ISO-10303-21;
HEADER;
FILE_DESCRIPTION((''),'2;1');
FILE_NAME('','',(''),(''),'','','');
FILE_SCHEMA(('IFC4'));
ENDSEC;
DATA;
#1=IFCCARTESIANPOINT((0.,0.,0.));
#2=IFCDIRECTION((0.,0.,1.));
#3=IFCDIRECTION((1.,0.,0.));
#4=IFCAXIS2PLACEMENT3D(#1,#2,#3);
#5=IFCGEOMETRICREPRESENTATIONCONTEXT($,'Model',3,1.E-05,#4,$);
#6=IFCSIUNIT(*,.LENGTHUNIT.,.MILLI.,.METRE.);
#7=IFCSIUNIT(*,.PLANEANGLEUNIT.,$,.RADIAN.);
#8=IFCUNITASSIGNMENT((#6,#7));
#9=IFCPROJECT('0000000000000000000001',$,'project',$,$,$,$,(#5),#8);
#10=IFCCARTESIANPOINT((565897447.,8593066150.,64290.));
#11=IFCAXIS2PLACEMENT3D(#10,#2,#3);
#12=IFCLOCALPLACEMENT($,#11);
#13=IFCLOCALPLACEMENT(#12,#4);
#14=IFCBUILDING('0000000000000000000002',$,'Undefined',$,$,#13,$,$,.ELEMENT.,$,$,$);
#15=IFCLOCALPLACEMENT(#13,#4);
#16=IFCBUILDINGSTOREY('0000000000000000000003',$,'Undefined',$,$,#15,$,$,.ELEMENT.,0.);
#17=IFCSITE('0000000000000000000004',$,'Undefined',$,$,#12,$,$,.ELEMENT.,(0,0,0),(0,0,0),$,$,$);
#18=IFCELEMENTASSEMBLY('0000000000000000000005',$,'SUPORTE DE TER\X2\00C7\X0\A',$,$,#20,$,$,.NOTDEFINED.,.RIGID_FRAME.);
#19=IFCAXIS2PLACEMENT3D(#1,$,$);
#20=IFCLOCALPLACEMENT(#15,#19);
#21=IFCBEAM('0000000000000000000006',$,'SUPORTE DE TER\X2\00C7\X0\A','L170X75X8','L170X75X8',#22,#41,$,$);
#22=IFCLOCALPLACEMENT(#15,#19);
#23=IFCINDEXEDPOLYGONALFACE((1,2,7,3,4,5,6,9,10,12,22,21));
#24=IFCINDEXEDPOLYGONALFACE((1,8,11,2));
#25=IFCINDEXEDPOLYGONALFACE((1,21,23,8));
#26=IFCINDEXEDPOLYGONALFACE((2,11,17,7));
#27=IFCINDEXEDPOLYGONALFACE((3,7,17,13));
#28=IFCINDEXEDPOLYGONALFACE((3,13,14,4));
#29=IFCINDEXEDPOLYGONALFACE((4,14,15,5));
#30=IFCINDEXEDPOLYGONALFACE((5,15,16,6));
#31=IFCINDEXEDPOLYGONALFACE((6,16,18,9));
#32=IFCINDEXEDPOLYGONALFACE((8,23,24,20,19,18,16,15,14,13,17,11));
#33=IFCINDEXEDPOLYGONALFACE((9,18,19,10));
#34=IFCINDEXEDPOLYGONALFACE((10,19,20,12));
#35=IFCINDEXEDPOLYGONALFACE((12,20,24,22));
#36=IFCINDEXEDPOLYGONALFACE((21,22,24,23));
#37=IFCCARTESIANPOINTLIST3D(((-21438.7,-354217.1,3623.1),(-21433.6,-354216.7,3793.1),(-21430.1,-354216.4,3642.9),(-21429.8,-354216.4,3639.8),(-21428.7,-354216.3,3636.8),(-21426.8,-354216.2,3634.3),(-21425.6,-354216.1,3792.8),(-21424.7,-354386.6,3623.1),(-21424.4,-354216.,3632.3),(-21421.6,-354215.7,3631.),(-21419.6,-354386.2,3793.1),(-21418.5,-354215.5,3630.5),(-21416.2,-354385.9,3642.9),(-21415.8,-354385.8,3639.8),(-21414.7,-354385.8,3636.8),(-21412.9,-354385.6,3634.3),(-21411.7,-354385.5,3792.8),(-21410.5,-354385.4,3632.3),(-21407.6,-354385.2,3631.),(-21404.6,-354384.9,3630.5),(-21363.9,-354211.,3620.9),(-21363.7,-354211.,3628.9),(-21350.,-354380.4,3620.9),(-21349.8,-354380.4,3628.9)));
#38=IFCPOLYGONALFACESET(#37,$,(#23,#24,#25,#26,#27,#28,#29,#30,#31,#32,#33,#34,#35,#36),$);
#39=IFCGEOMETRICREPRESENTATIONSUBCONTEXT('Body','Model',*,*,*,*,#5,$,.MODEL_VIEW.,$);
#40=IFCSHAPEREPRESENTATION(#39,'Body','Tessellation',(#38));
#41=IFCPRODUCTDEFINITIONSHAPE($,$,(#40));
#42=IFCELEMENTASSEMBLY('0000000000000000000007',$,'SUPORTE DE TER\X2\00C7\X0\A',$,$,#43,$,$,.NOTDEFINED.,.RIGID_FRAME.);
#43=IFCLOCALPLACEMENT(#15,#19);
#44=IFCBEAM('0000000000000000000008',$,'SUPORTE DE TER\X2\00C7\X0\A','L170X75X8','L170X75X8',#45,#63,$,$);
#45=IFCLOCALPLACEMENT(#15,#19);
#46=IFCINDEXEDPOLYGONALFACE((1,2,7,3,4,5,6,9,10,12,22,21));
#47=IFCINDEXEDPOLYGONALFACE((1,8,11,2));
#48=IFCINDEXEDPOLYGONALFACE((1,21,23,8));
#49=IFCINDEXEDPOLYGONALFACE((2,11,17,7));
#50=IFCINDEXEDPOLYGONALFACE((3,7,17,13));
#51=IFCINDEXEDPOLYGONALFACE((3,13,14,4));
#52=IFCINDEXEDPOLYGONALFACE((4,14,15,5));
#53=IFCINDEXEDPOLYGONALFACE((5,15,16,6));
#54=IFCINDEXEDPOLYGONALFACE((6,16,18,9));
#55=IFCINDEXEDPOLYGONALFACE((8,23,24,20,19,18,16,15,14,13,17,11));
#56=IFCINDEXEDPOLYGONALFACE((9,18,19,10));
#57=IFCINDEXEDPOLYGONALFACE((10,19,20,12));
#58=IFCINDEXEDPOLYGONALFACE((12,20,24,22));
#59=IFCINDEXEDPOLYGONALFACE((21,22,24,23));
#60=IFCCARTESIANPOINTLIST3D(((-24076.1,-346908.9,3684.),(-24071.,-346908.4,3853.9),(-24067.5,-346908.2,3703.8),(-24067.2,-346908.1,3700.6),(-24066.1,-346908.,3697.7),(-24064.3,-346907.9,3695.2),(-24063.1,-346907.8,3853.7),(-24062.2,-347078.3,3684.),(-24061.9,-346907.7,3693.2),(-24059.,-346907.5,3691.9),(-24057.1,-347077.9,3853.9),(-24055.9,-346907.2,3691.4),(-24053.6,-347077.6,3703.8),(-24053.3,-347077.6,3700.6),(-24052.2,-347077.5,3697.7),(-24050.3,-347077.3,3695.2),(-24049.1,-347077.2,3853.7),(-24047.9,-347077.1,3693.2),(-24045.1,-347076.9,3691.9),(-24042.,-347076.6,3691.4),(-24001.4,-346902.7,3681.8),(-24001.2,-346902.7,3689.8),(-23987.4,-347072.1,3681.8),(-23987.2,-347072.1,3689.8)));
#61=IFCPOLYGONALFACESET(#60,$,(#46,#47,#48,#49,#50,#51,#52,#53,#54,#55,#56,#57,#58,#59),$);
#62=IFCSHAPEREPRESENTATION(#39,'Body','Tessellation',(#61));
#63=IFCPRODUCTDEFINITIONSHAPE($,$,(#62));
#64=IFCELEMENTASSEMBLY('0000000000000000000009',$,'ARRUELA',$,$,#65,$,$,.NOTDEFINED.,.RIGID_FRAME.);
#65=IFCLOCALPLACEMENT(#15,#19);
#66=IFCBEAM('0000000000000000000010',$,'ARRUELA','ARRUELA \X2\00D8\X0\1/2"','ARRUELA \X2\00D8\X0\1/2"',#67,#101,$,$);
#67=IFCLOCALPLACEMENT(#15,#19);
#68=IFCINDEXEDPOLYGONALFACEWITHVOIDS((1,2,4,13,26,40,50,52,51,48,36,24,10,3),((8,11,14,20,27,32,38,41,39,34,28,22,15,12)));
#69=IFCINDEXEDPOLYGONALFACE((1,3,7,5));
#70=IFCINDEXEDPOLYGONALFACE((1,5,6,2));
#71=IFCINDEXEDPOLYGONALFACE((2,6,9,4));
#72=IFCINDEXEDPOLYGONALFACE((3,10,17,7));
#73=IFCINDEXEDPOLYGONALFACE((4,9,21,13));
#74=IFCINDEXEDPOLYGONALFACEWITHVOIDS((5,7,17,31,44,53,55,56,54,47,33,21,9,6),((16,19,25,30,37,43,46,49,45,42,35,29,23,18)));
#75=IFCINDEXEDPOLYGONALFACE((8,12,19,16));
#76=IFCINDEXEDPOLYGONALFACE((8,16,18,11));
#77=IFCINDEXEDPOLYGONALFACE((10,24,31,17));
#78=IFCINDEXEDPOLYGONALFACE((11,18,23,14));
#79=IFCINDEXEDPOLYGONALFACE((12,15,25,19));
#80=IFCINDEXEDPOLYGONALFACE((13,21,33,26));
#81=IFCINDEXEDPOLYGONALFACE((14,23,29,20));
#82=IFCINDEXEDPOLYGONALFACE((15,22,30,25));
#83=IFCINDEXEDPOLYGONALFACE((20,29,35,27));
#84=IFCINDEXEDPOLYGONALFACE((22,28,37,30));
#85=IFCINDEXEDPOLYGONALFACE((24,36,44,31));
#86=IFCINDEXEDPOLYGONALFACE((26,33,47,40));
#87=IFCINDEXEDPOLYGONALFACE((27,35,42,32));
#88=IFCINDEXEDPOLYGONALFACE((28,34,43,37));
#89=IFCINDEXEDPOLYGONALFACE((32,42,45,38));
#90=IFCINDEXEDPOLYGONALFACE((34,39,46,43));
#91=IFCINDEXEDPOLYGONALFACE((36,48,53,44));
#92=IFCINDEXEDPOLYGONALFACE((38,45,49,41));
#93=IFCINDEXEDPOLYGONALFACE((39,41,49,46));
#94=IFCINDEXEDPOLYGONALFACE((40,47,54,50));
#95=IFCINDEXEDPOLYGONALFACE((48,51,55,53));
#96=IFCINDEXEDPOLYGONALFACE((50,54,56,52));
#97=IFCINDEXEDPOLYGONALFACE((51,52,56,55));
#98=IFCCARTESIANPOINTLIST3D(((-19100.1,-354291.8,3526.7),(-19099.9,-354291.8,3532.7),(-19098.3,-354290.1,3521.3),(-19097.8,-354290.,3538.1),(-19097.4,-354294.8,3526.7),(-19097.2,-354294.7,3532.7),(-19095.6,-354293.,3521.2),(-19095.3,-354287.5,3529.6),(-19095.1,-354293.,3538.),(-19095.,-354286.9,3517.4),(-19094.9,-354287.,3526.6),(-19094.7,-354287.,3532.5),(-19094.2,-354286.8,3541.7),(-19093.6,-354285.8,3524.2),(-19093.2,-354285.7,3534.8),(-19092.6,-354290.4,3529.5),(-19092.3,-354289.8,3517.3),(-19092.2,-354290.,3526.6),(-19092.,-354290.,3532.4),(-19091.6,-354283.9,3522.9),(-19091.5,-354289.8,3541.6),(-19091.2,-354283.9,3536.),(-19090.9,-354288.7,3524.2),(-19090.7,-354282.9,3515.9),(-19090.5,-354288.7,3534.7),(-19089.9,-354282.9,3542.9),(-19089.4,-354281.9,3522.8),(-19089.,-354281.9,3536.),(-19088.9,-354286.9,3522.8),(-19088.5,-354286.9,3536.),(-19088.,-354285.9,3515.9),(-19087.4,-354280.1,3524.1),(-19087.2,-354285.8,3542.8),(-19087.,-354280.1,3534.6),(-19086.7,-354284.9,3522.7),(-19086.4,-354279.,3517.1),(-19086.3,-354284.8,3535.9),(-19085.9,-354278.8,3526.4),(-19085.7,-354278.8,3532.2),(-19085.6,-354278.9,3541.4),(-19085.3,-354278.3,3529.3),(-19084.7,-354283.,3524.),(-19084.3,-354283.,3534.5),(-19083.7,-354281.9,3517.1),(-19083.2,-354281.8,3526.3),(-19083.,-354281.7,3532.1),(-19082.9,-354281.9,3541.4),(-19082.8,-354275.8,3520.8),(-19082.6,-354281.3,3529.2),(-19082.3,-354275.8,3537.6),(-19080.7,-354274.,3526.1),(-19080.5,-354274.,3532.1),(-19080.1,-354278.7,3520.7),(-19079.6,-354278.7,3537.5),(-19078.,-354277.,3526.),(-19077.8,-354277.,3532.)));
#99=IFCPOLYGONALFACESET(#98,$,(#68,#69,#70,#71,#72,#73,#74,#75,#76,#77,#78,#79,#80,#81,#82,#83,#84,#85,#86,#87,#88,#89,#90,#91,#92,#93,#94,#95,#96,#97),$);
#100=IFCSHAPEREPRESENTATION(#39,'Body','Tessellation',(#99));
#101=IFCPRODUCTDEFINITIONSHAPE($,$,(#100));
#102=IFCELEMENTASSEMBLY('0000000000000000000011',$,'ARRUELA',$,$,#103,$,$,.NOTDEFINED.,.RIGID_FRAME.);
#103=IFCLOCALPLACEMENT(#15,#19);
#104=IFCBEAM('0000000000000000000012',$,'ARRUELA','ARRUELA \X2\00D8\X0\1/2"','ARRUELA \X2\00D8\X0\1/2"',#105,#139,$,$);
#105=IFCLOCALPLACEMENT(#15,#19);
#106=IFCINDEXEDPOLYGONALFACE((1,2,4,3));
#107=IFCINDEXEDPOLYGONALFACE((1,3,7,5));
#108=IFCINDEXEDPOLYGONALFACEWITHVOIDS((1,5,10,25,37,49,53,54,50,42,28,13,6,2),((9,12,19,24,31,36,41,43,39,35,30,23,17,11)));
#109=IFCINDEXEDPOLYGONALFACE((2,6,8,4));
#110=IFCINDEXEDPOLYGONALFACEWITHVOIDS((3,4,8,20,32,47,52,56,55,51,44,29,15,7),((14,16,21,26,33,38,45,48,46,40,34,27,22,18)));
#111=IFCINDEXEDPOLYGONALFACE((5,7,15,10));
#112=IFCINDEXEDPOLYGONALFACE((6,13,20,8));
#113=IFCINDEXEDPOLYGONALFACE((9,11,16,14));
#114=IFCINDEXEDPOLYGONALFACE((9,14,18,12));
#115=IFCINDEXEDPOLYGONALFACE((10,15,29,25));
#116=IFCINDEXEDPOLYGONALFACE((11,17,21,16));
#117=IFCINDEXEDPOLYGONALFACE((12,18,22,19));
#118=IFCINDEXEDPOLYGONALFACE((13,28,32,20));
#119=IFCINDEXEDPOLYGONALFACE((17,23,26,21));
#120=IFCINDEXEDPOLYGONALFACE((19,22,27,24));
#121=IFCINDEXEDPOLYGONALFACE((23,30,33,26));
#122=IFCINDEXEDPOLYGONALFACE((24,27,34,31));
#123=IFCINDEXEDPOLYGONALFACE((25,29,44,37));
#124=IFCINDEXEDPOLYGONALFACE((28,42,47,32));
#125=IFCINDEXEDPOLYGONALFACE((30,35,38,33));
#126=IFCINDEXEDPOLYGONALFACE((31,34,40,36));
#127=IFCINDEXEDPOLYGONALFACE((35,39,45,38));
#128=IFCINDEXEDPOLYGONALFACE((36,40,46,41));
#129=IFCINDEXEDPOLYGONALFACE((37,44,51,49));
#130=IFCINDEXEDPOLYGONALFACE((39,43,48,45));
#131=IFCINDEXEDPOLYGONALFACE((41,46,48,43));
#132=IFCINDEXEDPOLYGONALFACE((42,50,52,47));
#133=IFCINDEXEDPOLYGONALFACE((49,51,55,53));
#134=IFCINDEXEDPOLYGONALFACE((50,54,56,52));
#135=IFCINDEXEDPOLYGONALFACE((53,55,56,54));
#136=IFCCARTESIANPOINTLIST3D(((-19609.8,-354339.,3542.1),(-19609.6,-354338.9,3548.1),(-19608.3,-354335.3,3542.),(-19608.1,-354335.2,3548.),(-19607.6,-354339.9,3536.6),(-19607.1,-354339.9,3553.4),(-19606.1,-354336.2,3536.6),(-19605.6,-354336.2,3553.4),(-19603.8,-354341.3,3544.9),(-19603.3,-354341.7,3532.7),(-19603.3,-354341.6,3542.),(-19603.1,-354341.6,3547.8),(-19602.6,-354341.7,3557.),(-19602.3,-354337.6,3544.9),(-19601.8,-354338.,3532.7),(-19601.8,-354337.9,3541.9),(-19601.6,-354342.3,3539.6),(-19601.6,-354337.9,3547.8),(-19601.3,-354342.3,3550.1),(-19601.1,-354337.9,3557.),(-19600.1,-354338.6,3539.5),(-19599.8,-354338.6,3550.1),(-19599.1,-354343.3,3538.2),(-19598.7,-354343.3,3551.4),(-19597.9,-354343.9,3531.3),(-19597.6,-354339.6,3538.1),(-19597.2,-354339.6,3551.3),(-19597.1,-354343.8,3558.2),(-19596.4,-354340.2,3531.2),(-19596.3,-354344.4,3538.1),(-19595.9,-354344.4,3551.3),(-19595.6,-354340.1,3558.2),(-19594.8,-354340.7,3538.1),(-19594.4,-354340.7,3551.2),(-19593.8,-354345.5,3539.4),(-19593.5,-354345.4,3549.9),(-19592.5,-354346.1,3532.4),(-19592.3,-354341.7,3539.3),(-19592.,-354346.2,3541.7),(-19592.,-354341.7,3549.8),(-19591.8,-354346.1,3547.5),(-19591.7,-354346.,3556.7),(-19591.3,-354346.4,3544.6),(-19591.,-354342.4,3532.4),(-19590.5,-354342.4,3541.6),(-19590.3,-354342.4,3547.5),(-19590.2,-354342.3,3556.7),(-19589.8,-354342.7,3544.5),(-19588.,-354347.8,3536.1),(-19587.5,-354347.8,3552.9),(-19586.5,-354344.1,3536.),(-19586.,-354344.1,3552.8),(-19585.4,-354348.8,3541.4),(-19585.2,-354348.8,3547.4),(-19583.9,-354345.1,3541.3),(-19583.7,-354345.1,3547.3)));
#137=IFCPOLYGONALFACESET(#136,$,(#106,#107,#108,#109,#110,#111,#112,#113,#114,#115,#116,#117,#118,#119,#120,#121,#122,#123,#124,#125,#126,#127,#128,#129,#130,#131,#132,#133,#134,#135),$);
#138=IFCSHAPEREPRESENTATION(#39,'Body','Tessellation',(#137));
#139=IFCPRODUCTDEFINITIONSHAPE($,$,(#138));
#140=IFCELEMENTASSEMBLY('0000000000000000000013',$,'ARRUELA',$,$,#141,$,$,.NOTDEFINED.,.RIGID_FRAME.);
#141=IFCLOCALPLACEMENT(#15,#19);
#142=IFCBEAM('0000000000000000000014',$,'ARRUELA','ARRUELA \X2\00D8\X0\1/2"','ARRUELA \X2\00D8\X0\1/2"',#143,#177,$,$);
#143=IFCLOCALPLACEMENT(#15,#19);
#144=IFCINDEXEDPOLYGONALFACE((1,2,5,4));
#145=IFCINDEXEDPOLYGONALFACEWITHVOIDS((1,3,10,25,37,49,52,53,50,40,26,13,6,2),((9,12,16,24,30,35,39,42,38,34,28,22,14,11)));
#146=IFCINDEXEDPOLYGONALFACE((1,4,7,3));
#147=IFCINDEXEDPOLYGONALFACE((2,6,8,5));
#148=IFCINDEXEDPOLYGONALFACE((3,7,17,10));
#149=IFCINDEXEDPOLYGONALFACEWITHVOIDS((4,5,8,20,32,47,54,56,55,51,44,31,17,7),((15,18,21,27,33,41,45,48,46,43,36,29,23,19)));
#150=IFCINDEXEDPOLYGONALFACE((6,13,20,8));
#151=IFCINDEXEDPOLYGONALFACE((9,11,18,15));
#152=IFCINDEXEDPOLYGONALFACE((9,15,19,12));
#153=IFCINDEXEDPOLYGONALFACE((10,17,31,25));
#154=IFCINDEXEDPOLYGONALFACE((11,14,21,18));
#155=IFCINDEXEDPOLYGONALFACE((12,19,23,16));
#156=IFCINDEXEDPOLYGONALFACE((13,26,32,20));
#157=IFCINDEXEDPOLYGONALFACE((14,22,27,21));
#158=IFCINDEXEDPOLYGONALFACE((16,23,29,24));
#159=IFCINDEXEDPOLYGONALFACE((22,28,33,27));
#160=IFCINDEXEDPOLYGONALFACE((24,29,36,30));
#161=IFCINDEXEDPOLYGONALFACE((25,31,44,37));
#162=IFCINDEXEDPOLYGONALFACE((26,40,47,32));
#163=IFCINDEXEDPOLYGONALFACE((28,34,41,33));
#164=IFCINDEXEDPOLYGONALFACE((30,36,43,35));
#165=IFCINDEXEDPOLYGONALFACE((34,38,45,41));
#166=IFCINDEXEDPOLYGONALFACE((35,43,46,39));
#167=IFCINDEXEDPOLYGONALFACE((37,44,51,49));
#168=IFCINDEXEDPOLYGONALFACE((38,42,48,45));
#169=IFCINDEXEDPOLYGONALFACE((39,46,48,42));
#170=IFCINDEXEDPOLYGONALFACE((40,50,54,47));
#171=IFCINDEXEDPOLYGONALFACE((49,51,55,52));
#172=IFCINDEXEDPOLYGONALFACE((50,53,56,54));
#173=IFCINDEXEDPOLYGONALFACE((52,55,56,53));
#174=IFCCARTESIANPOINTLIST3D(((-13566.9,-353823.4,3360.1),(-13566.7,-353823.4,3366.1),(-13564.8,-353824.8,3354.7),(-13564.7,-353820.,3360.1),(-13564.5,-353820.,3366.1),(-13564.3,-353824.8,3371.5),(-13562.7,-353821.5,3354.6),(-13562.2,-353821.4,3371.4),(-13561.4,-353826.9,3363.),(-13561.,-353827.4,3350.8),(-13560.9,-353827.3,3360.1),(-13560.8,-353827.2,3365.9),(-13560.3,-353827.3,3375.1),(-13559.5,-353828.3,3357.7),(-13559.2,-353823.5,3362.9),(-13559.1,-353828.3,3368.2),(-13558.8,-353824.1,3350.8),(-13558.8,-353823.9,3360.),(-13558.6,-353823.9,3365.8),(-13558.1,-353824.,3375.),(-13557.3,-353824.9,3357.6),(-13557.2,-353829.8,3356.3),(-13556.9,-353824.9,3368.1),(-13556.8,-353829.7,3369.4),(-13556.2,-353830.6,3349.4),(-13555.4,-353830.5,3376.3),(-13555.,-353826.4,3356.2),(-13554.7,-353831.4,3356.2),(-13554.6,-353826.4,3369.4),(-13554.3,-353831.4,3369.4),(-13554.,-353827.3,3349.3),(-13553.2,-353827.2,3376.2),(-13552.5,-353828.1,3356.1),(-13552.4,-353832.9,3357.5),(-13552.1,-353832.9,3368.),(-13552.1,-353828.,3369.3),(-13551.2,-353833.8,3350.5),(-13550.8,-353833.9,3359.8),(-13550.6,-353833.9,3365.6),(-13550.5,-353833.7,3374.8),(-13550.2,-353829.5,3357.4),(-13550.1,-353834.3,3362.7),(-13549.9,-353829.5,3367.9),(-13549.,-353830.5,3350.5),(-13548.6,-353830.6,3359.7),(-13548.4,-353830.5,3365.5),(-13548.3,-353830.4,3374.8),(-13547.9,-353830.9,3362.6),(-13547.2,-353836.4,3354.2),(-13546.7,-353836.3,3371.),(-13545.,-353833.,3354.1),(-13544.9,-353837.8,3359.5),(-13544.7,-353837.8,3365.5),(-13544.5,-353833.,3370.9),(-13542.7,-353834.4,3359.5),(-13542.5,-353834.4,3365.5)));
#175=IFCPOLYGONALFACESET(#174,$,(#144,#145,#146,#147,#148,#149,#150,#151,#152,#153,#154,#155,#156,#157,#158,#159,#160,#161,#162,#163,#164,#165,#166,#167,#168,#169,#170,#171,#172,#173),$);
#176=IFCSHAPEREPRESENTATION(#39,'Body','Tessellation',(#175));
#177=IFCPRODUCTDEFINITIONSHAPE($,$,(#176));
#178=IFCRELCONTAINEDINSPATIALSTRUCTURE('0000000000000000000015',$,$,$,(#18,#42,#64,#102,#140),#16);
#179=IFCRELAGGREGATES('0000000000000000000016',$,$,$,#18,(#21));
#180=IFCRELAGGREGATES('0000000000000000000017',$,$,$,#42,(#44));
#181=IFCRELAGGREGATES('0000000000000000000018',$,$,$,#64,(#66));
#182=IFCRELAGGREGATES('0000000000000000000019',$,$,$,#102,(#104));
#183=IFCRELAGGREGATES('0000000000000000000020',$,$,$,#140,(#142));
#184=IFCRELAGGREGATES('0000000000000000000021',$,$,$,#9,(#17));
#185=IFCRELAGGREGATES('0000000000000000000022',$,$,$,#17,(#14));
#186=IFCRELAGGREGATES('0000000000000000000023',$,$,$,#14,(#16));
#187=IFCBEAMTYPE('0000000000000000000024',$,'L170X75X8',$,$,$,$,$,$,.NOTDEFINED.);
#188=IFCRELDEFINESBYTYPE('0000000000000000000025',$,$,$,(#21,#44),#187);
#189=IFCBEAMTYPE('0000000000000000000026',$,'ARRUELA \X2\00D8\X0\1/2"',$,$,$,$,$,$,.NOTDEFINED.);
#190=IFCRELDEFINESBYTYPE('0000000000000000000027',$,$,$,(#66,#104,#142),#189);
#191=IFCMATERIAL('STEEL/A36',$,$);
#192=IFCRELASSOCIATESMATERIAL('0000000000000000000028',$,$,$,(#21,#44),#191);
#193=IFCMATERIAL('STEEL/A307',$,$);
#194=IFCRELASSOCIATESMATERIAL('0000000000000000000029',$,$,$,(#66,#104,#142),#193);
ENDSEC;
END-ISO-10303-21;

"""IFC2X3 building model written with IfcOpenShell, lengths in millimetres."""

from ifc_helpers import new_model, si_unit, frame, origin_with_axes, origin_2d_with_axis, place, context, subcontext, project, spatial, polyline, l_section, outline, extrude, material, type_object, element, aggregate, save


model = new_model("IFC2X3")

# Units and contexts
model_context = context("Model", 3, precision=1e-05, world=origin_with_axes())
body_context = subcontext(model_context, "Body", "Model", "MODEL_VIEW")
ifc_project = project(units=[si_unit("LENGTHUNIT", "METRE", prefix="MILLI"), si_unit("PLANEANGLEUNIT", "RADIAN")], contexts=[model_context])

# Site, building, storey
site_placement = place(None, frame((565897447.0, 8593066150.0, 64290.0), z_axis=(0.0, 0.0, 1.0), x_axis=(1.0, 0.0, 0.0)))
site = spatial("IfcSite", under=ifc_project, at=site_placement, Name="Undefined", CompositionType="ELEMENT", RefLatitude=(0, 0, 0), RefLongitude=(0, 0, 0))
building_placement = place(site_placement, origin_with_axes())
building = spatial("IfcBuilding", under=site, at=building_placement, Name="Undefined", CompositionType="ELEMENT")
storey_placement = place(building_placement, origin_with_axes())
storey = spatial("IfcBuildingStorey", under=building, at=storey_placement, Name="Undefined", CompositionType="ELEMENT", Elevation=0.0)

# Element assemblies, beams
ifc_material_1 = material(Name="STEEL/A36")
beam_type_1 = type_object("IfcBeamType", Name="L170X75X8", PredefinedType="NOTDEFINED")
assembly_1_placement = place(storey_placement, origin_with_axes())
assembly_1 = element("IfcElementAssembly", 1, at=assembly_1_placement, inside=storey, Name="SUPORTE DE TERÇA", AssemblyPlace="NOTDEFINED", PredefinedType="RIGID_FRAME")
beam_1_placement = place(assembly_1_placement, frame((-21384.8, -354383.3, 3707.0), z_axis=(0.029885, 0.00246, 0.99955), x_axis=(-0.082025, 0.99663, 0.0)))
beam_1 = element("IfcBeam", 2, at=beam_1_placement, type_object=beam_type_1, material=ifc_material_1, Name="SUPORTE DE TERÇA", Description="L170X75X8", ObjectType="L170X75X8", context=body_context, shape_type="SweptSolid", body=[
    extrude(l_section(Depth=170.0, Width=75.0, Thickness=8.0, FilletRadius=12.0, at=origin_2d_with_axis()), frame((170.0, 0.0, 0.0), z_axis=(-1.0, 0.0, 0.0), x_axis=(0.0, -1.0, 0.0)), (0.0, 0.0, 1.0), 170.0),
])
aggregate(assembly_1, [beam_1])
assembly_2_placement = place(storey_placement, origin_with_axes())
assembly_2 = element("IfcElementAssembly", 3, at=assembly_2_placement, inside=storey, Name="SUPORTE DE TERÇA", AssemblyPlace="NOTDEFINED", PredefinedType="RIGID_FRAME")
beam_2_placement = place(assembly_2_placement, frame((-24022.3, -347075.0, 3767.8), z_axis=(0.029885, 0.00246, 0.99955), x_axis=(-0.082025, 0.99663, 0.0)))
beam_2 = element("IfcBeam", 4, at=beam_2_placement, type_object=beam_type_1, material=ifc_material_1, Name="SUPORTE DE TERÇA", Description="L170X75X8", ObjectType="L170X75X8", context=body_context, shape_type="SweptSolid", body=[
    extrude(l_section(Depth=170.0, Width=75.0, Thickness=8.0, FilletRadius=12.0, at=origin_2d_with_axis()), frame((170.0, 0.0, 0.0), z_axis=(-1.0, 0.0, 0.0), x_axis=(0.0, -1.0, 0.0)), (0.0, 0.0, 1.0), 170.0),
])
aggregate(assembly_2, [beam_2])
assembly_3_placement = place(storey_placement, origin_with_axes())
assembly_3 = element("IfcElementAssembly", 5, at=assembly_3_placement, inside=storey, Name="ARRUELA", AssemblyPlace="NOTDEFINED", PredefinedType="RIGID_FRAME")
ifc_material_2 = material(Name="STEEL/A307")
beam_type_2 = type_object("IfcBeamType", Name="ARRUELA Ø1/2\"", PredefinedType="NOTDEFINED")
beam_3_placement = place(assembly_3_placement, frame((-19090.3, -354282.9, 3529.4), z_axis=(-0.736334, -0.676203, 0.02368), x_axis=(0.675958, -0.736711, -0.018398)))
beam_3 = element("IfcBeam", 6, at=beam_3_placement, type_object=beam_type_2, material=ifc_material_2, Name="ARRUELA", Description="ARRUELA Ø1/2\"", ObjectType="ARRUELA Ø1/2\"", context=body_context, shape_type="SweptSolid", body=[
    extrude(outline(polyline([(-8.4, 10.5), (-3.0, 13.2), (3.0, 13.2), (8.4, 10.5), (12.2, 5.9), (13.5, 0.0), (12.2, -5.9), (8.4, -10.5), (3.0, -13.2), (-3.0, -13.2), (-8.4, -10.5), (-12.2, -5.9), (-13.5, 0.0), (-12.2, 5.9), (-8.4, 10.5)]), holes=[polyline([(5.3, 4.2), (2.9, 6.1), (0.0, 6.7), (-2.9, 6.1), (-5.3, 4.2), (-6.6, 1.5), (-6.6, -1.5), (-5.3, -4.2), (-2.9, -6.1), (0.0, -6.8), (2.9, -6.1), (5.3, -4.2), (6.6, -1.5), (6.6, 1.5), (5.3, 4.2)])]), frame((4.0, 0.0, 0.0), z_axis=(-1.0, 0.0, 0.0), x_axis=(0.0, -1.0, 0.0)), (0.0, 0.0, 1.0), 4.0),
])
aggregate(assembly_3, [beam_3])
assembly_4_placement = place(storey_placement, origin_with_axes())
assembly_4 = element("IfcElementAssembly", 7, at=assembly_4_placement, inside=storey, Name="ARRUELA", AssemblyPlace="NOTDEFINED", PredefinedType="RIGID_FRAME")
beam_4_placement = place(assembly_4_placement, frame((-19596.0, -354340.2, 3544.7), z_axis=(-0.92709, 0.373879, 0.026799), x_axis=(-0.373645, -0.927474, 0.013454)))
beam_4 = element("IfcBeam", 8, at=beam_4_placement, type_object=beam_type_2, material=ifc_material_2, Name="ARRUELA", Description="ARRUELA Ø1/2\"", ObjectType="ARRUELA Ø1/2\"", context=body_context, shape_type="SweptSolid", body=[
    extrude(outline(polyline([(-8.4, 10.5), (-3.0, 13.2), (3.0, 13.2), (8.4, 10.5), (12.2, 5.9), (13.5, 0.0), (12.2, -5.9), (8.4, -10.5), (3.0, -13.2), (-3.0, -13.2), (-8.4, -10.5), (-12.2, -5.9), (-13.5, 0.0), (-12.2, 5.9), (-8.4, 10.5)]), holes=[polyline([(5.3, 4.2), (2.9, 6.1), (0.0, 6.7), (-2.9, 6.1), (-5.3, 4.2), (-6.6, 1.5), (-6.6, -1.5), (-5.3, -4.2), (-2.9, -6.1), (0.0, -6.8), (2.9, -6.1), (5.3, -4.2), (6.6, -1.5), (6.6, 1.5), (5.3, 4.2)])]), frame((4.0, 0.0, 0.0), z_axis=(-1.0, 0.0, 0.0), x_axis=(0.0, -1.0, 0.0)), (0.0, 0.0, 1.0), 4.0),
])
aggregate(assembly_4, [beam_4])
assembly_5_placement = place(storey_placement, origin_with_axes())
assembly_5 = element("IfcElementAssembly", 9, at=assembly_5_placement, inside=storey, Name="ARRUELA", AssemblyPlace="NOTDEFINED", PredefinedType="RIGID_FRAME")
beam_5_placement = place(assembly_5_placement, frame((-13553.6, -353827.2, 3362.8), z_axis=(-0.836984, 0.546715, 0.02368), x_axis=(-0.546411, -0.837315, 0.018398)))
beam_5 = element("IfcBeam", 10, at=beam_5_placement, type_object=beam_type_2, material=ifc_material_2, Name="ARRUELA", Description="ARRUELA Ø1/2\"", ObjectType="ARRUELA Ø1/2\"", context=body_context, shape_type="SweptSolid", body=[
    extrude(outline(polyline([(-8.4, 10.5), (-3.0, 13.2), (3.0, 13.2), (8.4, 10.5), (12.2, 5.9), (13.5, 0.0), (12.2, -5.9), (8.4, -10.5), (3.0, -13.2), (-3.0, -13.2), (-8.4, -10.5), (-12.2, -5.9), (-13.5, 0.0), (-12.2, 5.9), (-8.4, 10.5)]), holes=[polyline([(5.3, 4.2), (2.9, 6.1), (0.0, 6.7), (-2.9, 6.1), (-5.3, 4.2), (-6.6, 1.5), (-6.6, -1.5), (-5.3, -4.2), (-2.9, -6.1), (0.0, -6.8), (2.9, -6.1), (5.3, -4.2), (6.6, -1.5), (6.6, 1.5), (5.3, 4.2)])]), frame((4.0, 0.0, 0.0), z_axis=(-1.0, 0.0, 0.0), x_axis=(0.0, -1.0, 0.0)), (0.0, 0.0, 1.0), 4.0),
])
aggregate(assembly_5, [beam_5])

save(model, "model.ifc")
